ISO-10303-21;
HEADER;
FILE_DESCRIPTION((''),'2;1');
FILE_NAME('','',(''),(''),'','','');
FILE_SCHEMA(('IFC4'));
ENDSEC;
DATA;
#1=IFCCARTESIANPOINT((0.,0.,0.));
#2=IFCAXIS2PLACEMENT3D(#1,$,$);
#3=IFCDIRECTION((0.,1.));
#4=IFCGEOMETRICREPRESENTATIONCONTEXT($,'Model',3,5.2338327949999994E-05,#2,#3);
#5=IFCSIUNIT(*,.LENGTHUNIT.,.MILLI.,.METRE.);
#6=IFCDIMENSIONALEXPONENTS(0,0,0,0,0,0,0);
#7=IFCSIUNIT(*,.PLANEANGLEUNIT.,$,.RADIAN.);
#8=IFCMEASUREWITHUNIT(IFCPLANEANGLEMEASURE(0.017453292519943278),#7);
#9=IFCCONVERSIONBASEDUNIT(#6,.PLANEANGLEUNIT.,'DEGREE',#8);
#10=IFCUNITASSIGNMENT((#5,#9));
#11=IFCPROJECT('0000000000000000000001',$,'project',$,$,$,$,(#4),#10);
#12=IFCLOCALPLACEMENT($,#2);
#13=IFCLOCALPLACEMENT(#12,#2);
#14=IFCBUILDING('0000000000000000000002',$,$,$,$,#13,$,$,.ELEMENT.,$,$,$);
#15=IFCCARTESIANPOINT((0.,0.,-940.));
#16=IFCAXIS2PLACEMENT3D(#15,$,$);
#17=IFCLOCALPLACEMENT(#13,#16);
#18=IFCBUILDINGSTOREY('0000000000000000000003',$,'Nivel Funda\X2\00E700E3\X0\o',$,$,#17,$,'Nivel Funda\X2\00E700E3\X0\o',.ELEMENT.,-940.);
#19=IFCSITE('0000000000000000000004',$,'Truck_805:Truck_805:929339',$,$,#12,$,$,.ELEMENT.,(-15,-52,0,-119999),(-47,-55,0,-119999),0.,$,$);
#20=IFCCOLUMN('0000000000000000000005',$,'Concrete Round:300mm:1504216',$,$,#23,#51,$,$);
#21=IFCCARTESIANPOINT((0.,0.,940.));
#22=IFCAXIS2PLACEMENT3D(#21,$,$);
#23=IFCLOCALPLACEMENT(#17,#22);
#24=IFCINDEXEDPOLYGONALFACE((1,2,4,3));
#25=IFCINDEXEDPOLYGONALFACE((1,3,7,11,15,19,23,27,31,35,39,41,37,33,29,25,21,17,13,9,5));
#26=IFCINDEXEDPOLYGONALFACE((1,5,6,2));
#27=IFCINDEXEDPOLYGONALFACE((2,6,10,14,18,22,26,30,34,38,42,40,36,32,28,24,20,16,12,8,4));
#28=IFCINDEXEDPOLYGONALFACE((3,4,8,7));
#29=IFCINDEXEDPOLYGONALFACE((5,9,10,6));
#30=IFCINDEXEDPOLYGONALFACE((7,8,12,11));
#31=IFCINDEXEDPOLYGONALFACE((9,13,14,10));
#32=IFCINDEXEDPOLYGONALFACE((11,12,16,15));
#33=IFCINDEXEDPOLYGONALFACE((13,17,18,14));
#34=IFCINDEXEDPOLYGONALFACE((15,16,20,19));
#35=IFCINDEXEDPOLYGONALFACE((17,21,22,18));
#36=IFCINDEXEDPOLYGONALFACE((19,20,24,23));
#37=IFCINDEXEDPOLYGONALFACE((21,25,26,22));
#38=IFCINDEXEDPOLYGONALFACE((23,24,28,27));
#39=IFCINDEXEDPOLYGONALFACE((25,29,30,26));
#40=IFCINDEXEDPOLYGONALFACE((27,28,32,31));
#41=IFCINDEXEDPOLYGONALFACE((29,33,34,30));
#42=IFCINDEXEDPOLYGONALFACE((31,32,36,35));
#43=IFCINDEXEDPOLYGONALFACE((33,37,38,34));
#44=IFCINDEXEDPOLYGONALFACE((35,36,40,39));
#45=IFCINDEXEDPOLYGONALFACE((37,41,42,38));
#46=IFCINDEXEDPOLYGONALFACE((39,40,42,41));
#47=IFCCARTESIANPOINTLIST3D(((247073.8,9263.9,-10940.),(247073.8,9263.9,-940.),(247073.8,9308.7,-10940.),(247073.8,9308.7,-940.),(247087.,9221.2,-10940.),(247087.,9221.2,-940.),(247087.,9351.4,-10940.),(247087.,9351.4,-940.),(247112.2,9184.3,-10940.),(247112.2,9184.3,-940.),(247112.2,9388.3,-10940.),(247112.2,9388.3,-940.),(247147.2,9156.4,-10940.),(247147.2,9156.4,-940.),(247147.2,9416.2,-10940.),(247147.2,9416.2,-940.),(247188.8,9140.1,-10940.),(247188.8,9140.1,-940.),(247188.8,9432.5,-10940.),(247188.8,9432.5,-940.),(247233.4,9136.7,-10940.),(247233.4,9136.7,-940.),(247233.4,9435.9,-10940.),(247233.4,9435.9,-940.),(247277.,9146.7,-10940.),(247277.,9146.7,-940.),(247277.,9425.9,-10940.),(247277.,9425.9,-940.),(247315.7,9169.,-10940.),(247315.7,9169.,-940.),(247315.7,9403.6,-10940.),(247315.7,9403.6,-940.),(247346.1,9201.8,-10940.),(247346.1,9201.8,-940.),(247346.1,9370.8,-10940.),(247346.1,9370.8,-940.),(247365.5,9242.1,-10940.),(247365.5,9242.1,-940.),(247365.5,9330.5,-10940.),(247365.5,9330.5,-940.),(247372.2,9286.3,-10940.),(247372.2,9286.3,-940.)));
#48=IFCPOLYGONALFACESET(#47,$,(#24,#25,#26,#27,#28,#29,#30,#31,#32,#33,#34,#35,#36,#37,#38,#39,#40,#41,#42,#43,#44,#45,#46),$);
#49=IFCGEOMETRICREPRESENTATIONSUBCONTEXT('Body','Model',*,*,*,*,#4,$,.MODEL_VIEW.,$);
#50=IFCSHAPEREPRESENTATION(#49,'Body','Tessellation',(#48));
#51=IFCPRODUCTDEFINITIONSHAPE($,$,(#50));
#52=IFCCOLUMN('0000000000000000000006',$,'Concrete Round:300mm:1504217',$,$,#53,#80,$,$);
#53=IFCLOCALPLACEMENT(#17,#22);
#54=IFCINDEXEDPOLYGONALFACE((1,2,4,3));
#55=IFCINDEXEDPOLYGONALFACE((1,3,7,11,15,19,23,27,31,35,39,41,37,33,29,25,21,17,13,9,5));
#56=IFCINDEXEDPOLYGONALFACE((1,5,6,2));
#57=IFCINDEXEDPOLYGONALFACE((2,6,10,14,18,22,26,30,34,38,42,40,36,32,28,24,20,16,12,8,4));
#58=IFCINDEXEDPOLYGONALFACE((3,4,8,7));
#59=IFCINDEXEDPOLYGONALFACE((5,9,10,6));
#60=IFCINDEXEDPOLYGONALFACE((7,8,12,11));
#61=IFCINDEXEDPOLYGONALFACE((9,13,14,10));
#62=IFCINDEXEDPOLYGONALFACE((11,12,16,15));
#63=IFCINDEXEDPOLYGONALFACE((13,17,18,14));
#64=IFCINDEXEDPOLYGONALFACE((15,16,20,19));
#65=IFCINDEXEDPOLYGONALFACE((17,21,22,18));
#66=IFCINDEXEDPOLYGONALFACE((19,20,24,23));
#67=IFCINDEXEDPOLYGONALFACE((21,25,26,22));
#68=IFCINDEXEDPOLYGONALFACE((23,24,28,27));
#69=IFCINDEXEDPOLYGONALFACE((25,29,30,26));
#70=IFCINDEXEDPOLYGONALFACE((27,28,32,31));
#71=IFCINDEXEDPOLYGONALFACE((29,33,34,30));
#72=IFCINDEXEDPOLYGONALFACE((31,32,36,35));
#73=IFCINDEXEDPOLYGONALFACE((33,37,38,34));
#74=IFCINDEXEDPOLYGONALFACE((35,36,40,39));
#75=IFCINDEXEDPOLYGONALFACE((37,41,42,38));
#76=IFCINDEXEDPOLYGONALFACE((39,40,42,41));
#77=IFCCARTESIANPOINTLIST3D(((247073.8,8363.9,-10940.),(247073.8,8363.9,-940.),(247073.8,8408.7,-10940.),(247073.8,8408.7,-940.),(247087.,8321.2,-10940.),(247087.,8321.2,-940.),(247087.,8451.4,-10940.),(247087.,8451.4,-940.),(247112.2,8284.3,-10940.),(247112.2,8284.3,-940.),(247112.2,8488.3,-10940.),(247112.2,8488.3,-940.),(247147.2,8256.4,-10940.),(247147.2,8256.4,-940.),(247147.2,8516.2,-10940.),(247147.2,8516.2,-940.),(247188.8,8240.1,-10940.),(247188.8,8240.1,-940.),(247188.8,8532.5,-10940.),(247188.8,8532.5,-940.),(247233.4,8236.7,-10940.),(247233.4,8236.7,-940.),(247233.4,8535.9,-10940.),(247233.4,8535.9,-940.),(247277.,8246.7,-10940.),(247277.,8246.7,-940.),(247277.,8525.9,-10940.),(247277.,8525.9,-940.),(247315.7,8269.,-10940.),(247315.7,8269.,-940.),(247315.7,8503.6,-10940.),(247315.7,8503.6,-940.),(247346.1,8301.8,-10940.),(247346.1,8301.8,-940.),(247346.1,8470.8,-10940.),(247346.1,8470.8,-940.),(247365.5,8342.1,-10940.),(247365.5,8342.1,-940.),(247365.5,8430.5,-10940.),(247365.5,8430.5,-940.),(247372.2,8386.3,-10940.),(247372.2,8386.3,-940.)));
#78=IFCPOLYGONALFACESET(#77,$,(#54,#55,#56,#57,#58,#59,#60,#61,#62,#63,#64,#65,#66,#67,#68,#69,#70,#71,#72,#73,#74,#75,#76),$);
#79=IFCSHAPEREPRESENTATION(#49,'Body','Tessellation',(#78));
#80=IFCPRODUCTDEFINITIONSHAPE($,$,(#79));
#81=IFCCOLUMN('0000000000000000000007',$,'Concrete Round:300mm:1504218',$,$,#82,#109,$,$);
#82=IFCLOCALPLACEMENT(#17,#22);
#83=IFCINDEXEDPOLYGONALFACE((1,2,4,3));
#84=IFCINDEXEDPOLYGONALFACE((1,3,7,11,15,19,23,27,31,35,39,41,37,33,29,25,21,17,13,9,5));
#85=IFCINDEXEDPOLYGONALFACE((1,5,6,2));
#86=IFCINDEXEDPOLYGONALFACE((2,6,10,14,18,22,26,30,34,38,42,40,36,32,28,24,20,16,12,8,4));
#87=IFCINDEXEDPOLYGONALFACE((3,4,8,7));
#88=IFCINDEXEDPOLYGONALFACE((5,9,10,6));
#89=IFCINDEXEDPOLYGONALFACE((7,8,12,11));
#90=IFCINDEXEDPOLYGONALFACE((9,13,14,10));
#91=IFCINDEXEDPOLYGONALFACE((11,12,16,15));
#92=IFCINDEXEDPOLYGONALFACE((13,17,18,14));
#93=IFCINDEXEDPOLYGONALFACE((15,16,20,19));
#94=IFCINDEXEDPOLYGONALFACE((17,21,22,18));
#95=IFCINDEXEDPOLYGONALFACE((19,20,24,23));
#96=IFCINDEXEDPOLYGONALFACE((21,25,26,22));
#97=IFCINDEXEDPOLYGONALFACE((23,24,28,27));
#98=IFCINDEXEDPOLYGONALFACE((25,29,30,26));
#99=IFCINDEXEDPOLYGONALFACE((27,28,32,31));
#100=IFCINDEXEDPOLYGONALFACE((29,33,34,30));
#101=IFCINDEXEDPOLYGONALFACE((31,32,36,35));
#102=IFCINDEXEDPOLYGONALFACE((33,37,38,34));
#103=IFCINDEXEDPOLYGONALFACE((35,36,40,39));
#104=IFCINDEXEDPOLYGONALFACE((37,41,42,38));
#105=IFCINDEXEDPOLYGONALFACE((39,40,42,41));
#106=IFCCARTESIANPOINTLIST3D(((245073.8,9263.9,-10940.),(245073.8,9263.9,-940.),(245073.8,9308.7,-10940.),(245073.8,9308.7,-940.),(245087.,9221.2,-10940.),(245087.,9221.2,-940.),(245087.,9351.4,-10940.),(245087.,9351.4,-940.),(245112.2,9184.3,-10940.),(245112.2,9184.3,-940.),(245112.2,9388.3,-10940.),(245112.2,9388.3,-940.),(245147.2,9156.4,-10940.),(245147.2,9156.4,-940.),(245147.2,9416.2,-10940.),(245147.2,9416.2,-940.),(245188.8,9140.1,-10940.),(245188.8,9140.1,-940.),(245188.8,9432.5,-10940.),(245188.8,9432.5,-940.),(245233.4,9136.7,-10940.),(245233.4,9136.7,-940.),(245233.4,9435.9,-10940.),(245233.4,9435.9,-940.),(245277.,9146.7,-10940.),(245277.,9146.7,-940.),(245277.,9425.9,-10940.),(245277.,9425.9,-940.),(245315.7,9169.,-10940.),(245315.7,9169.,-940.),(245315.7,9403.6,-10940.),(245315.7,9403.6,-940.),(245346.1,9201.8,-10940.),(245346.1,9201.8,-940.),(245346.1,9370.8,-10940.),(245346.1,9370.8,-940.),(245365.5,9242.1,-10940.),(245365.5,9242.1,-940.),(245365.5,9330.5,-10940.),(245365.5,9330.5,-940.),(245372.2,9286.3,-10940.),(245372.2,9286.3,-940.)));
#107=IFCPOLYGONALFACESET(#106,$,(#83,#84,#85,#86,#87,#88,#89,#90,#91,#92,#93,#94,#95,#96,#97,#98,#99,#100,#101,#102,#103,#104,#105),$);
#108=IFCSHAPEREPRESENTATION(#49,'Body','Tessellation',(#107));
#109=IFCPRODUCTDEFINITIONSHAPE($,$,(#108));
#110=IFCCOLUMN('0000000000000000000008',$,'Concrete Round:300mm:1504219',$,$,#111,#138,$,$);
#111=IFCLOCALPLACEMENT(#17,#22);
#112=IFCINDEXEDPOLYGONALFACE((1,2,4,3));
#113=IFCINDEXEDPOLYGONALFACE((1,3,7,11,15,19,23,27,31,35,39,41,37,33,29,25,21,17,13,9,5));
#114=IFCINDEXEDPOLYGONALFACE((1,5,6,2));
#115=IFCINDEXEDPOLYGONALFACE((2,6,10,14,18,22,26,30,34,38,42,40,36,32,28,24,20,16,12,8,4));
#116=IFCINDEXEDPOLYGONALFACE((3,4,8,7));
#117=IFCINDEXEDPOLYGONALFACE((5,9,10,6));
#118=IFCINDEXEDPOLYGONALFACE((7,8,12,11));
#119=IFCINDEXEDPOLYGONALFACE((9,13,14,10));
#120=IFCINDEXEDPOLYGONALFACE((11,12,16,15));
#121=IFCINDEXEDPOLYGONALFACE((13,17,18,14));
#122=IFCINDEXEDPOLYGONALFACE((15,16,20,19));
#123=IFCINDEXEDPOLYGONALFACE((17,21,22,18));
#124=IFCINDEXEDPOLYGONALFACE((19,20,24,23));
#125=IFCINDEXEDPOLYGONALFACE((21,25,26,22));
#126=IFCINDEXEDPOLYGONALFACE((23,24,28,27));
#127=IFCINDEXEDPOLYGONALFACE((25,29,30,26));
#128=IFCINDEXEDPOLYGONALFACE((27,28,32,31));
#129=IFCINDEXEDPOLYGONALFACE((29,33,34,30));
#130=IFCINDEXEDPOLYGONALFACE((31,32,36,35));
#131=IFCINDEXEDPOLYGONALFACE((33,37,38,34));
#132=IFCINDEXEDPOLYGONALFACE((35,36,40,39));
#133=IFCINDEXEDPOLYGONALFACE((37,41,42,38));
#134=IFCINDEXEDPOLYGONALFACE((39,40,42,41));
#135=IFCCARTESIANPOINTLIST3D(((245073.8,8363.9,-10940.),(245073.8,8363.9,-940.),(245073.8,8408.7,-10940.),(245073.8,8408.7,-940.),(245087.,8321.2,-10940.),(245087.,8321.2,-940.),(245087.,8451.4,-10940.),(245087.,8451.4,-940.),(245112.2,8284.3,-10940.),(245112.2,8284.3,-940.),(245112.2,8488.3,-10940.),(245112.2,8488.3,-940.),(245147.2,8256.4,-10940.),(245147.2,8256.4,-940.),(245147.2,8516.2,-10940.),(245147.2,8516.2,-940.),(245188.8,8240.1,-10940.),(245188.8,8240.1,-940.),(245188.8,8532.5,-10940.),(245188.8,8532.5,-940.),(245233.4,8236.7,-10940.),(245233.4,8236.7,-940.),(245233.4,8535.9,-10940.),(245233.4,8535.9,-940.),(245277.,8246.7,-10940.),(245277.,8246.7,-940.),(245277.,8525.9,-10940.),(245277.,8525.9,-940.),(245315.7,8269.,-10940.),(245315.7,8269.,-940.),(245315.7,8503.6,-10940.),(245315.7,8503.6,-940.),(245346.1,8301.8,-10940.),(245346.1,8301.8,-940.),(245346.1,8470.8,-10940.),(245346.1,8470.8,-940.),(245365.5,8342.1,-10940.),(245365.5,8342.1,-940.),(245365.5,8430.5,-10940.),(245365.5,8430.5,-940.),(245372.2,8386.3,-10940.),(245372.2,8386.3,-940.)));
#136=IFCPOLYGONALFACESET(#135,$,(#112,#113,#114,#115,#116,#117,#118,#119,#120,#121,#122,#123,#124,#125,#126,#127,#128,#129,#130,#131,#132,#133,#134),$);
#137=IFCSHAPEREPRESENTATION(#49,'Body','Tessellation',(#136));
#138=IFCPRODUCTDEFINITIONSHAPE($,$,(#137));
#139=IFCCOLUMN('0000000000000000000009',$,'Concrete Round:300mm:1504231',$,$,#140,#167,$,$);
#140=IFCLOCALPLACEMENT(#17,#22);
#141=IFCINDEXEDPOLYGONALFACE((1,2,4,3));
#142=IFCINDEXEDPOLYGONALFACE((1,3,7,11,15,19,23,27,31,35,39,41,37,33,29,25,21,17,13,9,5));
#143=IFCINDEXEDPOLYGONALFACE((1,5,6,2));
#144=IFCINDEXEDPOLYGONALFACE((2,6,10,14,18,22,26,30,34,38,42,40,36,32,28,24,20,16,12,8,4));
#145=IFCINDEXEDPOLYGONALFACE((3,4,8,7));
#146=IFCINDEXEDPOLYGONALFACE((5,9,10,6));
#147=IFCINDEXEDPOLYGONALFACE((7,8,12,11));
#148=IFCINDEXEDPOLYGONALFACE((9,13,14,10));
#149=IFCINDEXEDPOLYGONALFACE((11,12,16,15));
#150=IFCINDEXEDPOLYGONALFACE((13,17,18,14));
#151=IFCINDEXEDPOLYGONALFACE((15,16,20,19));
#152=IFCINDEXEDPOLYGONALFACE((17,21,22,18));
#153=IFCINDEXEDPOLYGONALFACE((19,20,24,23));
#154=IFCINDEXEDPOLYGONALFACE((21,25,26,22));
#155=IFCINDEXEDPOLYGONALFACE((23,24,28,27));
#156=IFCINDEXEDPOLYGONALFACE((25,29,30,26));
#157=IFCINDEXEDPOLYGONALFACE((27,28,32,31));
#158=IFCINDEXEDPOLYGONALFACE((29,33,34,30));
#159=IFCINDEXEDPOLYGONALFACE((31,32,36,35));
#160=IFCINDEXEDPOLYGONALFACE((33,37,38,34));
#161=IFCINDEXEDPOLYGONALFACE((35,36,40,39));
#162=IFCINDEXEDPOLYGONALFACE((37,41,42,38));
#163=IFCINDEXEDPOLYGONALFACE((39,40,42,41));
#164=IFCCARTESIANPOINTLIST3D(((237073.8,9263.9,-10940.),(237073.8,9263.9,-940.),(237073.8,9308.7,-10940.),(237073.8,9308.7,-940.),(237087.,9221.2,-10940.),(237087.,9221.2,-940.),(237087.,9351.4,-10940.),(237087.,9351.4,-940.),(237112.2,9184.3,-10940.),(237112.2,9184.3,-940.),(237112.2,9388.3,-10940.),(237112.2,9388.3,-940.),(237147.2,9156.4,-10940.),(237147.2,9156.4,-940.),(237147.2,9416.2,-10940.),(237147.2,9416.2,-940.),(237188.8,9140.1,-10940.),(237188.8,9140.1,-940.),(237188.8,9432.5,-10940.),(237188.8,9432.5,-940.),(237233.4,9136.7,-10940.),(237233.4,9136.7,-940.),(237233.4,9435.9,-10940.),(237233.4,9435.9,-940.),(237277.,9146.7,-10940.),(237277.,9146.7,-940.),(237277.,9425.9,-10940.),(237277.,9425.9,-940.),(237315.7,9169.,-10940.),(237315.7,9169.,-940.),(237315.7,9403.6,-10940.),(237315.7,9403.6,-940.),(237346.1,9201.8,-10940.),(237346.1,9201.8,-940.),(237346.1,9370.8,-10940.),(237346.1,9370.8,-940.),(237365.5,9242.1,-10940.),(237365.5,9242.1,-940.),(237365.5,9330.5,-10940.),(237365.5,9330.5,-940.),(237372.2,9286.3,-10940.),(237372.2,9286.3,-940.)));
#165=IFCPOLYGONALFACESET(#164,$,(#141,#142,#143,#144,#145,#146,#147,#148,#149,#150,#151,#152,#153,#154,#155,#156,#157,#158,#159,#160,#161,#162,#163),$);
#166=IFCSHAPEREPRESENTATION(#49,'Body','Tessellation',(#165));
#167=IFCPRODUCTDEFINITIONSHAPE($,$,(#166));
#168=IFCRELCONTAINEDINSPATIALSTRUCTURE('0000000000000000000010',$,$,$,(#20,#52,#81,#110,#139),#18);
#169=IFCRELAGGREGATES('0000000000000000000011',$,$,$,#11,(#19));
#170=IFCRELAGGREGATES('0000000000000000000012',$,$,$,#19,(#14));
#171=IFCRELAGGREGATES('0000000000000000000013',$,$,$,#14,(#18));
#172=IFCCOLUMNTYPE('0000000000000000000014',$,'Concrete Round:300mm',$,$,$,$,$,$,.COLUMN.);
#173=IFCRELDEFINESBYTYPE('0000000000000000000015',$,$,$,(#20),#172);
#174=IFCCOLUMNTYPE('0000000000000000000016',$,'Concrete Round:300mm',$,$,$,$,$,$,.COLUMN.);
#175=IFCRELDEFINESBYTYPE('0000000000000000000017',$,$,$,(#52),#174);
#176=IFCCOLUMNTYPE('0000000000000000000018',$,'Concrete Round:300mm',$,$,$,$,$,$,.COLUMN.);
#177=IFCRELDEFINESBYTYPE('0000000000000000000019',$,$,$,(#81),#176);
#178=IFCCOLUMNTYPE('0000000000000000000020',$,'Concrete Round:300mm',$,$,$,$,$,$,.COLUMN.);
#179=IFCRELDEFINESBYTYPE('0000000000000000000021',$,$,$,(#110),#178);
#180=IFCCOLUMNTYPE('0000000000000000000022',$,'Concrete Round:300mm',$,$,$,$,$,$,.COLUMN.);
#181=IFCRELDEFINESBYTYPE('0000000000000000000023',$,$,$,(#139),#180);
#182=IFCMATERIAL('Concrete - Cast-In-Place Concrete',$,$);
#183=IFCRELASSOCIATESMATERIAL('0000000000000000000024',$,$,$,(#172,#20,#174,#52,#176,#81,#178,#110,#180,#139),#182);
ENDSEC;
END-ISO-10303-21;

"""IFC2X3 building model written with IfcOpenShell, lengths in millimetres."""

from ifc_helpers import new_model, entity, si_unit, converted_unit, direction, frame, origin, origin_2d_with_axis, place, context, subcontext, project, spatial, circle, extrude, source, transform, mapped, material, type_object, type_shapes, element, save


model = new_model("IFC2X3")

# Units and contexts
model_context = context("Model", 3, precision=5.2338327949999994e-05, world=origin(), true_north=direction((0.0, 1.0)))
body_context = subcontext(model_context, "Body", "Model", "MODEL_VIEW")
ifc_project = project(units=[si_unit("LENGTHUNIT", "METRE", prefix="MILLI"), converted_unit("PLANEANGLEUNIT", "DEGREE", entity("IfcPlaneAngleMeasure", 0.017453292519943278), si_unit("PLANEANGLEUNIT", "RADIAN"), dimensions=[0, 0, 0, 0, 0, 0, 0])], contexts=[model_context])

# Site, building, storey
site_placement = place(None, origin())
site = spatial("IfcSite", under=ifc_project, at=site_placement, Name="Truck_805:Truck_805:929339", CompositionType="ELEMENT", RefLatitude=(-15, -52, 0, -119999), RefLongitude=(-47, -55, 0, -119999), RefElevation=0.0)
building_placement = place(site_placement, origin())
building = spatial("IfcBuilding", under=site, at=building_placement, CompositionType="ELEMENT")
storey_placement = place(building_placement, frame((0.0, 0.0, -940.0)))
storey = spatial("IfcBuildingStorey", under=building, at=storey_placement, Name="Nivel Fundação", LongName="Nivel Fundação", CompositionType="ELEMENT", Elevation=-940.0)

# Columns
ifc_material = material(Name="Concrete - Cast-In-Place Concrete")
column_type_1 = type_object("IfcColumnType", Name="Concrete Round:300mm", PredefinedType="COLUMN", material=ifc_material)
shared_shape_1 = source(origin(), body_context, "Body", "SweptSolid", [
    extrude(circle(Radius=150.0, at=origin_2d_with_axis()), frame((247222.2, 9286.3, -10940.0)), (0.0, 0.0, 1.0), 10000.0),
])
type_shapes(column_type_1, [shared_shape_1])
column_1_placement = place(storey_placement, frame((0.0, 0.0, 940.0)))
element("IfcColumn", 1, at=column_1_placement, inside=storey, type_object=column_type_1, material=ifc_material, Name="Concrete Round:300mm:1504216", context=body_context, shape_type="MappedRepresentation", body=[
    mapped(shared_shape_1, transform((0.0, 0.0, 0.0), scale=1.0)),
])
column_type_2 = type_object("IfcColumnType", Name="Concrete Round:300mm", PredefinedType="COLUMN", material=ifc_material)
shared_shape_2 = source(origin(), body_context, "Body", "SweptSolid", [
    extrude(circle(Radius=150.0, at=origin_2d_with_axis()), frame((247222.2, 8386.3, -10940.0)), (0.0, 0.0, 1.0), 10000.0),
])
type_shapes(column_type_2, [shared_shape_2])
column_2_placement = place(storey_placement, frame((0.0, 0.0, 940.0)))
element("IfcColumn", 2, at=column_2_placement, inside=storey, type_object=column_type_2, material=ifc_material, Name="Concrete Round:300mm:1504217", context=body_context, shape_type="MappedRepresentation", body=[
    mapped(shared_shape_2, transform((0.0, 0.0, 0.0), scale=1.0)),
])
column_type_3 = type_object("IfcColumnType", Name="Concrete Round:300mm", PredefinedType="COLUMN", material=ifc_material)
shared_shape_3 = source(origin(), body_context, "Body", "SweptSolid", [
    extrude(circle(Radius=150.0, at=origin_2d_with_axis()), frame((245222.2, 9286.3, -10940.0)), (0.0, 0.0, 1.0), 10000.0),
])
type_shapes(column_type_3, [shared_shape_3])
column_3_placement = place(storey_placement, frame((0.0, 0.0, 940.0)))
element("IfcColumn", 3, at=column_3_placement, inside=storey, type_object=column_type_3, material=ifc_material, Name="Concrete Round:300mm:1504218", context=body_context, shape_type="MappedRepresentation", body=[
    mapped(shared_shape_3, transform((0.0, 0.0, 0.0), scale=1.0)),
])
column_type_4 = type_object("IfcColumnType", Name="Concrete Round:300mm", PredefinedType="COLUMN", material=ifc_material)
shared_shape_4 = source(origin(), body_context, "Body", "SweptSolid", [
    extrude(circle(Radius=150.0, at=origin_2d_with_axis()), frame((245222.2, 8386.3, -10940.0)), (0.0, 0.0, 1.0), 10000.0),
])
type_shapes(column_type_4, [shared_shape_4])
column_4_placement = place(storey_placement, frame((0.0, 0.0, 940.0)))
element("IfcColumn", 4, at=column_4_placement, inside=storey, type_object=column_type_4, material=ifc_material, Name="Concrete Round:300mm:1504219", context=body_context, shape_type="MappedRepresentation", body=[
    mapped(shared_shape_4, transform((0.0, 0.0, 0.0), scale=1.0)),
])
column_type_5 = type_object("IfcColumnType", Name="Concrete Round:300mm", PredefinedType="COLUMN", material=ifc_material)
shared_shape_5 = source(origin(), body_context, "Body", "SweptSolid", [
    extrude(circle(Radius=150.0, at=origin_2d_with_axis()), frame((237222.2, 9286.3, -10940.0)), (0.0, 0.0, 1.0), 10000.0),
])
type_shapes(column_type_5, [shared_shape_5])
column_5_placement = place(storey_placement, frame((0.0, 0.0, 940.0)))
element("IfcColumn", 5, at=column_5_placement, inside=storey, type_object=column_type_5, material=ifc_material, Name="Concrete Round:300mm:1504231", context=body_context, shape_type="MappedRepresentation", body=[
    mapped(shared_shape_5, transform((0.0, 0.0, 0.0), scale=1.0)),
])

save(model, "model.ifc")
